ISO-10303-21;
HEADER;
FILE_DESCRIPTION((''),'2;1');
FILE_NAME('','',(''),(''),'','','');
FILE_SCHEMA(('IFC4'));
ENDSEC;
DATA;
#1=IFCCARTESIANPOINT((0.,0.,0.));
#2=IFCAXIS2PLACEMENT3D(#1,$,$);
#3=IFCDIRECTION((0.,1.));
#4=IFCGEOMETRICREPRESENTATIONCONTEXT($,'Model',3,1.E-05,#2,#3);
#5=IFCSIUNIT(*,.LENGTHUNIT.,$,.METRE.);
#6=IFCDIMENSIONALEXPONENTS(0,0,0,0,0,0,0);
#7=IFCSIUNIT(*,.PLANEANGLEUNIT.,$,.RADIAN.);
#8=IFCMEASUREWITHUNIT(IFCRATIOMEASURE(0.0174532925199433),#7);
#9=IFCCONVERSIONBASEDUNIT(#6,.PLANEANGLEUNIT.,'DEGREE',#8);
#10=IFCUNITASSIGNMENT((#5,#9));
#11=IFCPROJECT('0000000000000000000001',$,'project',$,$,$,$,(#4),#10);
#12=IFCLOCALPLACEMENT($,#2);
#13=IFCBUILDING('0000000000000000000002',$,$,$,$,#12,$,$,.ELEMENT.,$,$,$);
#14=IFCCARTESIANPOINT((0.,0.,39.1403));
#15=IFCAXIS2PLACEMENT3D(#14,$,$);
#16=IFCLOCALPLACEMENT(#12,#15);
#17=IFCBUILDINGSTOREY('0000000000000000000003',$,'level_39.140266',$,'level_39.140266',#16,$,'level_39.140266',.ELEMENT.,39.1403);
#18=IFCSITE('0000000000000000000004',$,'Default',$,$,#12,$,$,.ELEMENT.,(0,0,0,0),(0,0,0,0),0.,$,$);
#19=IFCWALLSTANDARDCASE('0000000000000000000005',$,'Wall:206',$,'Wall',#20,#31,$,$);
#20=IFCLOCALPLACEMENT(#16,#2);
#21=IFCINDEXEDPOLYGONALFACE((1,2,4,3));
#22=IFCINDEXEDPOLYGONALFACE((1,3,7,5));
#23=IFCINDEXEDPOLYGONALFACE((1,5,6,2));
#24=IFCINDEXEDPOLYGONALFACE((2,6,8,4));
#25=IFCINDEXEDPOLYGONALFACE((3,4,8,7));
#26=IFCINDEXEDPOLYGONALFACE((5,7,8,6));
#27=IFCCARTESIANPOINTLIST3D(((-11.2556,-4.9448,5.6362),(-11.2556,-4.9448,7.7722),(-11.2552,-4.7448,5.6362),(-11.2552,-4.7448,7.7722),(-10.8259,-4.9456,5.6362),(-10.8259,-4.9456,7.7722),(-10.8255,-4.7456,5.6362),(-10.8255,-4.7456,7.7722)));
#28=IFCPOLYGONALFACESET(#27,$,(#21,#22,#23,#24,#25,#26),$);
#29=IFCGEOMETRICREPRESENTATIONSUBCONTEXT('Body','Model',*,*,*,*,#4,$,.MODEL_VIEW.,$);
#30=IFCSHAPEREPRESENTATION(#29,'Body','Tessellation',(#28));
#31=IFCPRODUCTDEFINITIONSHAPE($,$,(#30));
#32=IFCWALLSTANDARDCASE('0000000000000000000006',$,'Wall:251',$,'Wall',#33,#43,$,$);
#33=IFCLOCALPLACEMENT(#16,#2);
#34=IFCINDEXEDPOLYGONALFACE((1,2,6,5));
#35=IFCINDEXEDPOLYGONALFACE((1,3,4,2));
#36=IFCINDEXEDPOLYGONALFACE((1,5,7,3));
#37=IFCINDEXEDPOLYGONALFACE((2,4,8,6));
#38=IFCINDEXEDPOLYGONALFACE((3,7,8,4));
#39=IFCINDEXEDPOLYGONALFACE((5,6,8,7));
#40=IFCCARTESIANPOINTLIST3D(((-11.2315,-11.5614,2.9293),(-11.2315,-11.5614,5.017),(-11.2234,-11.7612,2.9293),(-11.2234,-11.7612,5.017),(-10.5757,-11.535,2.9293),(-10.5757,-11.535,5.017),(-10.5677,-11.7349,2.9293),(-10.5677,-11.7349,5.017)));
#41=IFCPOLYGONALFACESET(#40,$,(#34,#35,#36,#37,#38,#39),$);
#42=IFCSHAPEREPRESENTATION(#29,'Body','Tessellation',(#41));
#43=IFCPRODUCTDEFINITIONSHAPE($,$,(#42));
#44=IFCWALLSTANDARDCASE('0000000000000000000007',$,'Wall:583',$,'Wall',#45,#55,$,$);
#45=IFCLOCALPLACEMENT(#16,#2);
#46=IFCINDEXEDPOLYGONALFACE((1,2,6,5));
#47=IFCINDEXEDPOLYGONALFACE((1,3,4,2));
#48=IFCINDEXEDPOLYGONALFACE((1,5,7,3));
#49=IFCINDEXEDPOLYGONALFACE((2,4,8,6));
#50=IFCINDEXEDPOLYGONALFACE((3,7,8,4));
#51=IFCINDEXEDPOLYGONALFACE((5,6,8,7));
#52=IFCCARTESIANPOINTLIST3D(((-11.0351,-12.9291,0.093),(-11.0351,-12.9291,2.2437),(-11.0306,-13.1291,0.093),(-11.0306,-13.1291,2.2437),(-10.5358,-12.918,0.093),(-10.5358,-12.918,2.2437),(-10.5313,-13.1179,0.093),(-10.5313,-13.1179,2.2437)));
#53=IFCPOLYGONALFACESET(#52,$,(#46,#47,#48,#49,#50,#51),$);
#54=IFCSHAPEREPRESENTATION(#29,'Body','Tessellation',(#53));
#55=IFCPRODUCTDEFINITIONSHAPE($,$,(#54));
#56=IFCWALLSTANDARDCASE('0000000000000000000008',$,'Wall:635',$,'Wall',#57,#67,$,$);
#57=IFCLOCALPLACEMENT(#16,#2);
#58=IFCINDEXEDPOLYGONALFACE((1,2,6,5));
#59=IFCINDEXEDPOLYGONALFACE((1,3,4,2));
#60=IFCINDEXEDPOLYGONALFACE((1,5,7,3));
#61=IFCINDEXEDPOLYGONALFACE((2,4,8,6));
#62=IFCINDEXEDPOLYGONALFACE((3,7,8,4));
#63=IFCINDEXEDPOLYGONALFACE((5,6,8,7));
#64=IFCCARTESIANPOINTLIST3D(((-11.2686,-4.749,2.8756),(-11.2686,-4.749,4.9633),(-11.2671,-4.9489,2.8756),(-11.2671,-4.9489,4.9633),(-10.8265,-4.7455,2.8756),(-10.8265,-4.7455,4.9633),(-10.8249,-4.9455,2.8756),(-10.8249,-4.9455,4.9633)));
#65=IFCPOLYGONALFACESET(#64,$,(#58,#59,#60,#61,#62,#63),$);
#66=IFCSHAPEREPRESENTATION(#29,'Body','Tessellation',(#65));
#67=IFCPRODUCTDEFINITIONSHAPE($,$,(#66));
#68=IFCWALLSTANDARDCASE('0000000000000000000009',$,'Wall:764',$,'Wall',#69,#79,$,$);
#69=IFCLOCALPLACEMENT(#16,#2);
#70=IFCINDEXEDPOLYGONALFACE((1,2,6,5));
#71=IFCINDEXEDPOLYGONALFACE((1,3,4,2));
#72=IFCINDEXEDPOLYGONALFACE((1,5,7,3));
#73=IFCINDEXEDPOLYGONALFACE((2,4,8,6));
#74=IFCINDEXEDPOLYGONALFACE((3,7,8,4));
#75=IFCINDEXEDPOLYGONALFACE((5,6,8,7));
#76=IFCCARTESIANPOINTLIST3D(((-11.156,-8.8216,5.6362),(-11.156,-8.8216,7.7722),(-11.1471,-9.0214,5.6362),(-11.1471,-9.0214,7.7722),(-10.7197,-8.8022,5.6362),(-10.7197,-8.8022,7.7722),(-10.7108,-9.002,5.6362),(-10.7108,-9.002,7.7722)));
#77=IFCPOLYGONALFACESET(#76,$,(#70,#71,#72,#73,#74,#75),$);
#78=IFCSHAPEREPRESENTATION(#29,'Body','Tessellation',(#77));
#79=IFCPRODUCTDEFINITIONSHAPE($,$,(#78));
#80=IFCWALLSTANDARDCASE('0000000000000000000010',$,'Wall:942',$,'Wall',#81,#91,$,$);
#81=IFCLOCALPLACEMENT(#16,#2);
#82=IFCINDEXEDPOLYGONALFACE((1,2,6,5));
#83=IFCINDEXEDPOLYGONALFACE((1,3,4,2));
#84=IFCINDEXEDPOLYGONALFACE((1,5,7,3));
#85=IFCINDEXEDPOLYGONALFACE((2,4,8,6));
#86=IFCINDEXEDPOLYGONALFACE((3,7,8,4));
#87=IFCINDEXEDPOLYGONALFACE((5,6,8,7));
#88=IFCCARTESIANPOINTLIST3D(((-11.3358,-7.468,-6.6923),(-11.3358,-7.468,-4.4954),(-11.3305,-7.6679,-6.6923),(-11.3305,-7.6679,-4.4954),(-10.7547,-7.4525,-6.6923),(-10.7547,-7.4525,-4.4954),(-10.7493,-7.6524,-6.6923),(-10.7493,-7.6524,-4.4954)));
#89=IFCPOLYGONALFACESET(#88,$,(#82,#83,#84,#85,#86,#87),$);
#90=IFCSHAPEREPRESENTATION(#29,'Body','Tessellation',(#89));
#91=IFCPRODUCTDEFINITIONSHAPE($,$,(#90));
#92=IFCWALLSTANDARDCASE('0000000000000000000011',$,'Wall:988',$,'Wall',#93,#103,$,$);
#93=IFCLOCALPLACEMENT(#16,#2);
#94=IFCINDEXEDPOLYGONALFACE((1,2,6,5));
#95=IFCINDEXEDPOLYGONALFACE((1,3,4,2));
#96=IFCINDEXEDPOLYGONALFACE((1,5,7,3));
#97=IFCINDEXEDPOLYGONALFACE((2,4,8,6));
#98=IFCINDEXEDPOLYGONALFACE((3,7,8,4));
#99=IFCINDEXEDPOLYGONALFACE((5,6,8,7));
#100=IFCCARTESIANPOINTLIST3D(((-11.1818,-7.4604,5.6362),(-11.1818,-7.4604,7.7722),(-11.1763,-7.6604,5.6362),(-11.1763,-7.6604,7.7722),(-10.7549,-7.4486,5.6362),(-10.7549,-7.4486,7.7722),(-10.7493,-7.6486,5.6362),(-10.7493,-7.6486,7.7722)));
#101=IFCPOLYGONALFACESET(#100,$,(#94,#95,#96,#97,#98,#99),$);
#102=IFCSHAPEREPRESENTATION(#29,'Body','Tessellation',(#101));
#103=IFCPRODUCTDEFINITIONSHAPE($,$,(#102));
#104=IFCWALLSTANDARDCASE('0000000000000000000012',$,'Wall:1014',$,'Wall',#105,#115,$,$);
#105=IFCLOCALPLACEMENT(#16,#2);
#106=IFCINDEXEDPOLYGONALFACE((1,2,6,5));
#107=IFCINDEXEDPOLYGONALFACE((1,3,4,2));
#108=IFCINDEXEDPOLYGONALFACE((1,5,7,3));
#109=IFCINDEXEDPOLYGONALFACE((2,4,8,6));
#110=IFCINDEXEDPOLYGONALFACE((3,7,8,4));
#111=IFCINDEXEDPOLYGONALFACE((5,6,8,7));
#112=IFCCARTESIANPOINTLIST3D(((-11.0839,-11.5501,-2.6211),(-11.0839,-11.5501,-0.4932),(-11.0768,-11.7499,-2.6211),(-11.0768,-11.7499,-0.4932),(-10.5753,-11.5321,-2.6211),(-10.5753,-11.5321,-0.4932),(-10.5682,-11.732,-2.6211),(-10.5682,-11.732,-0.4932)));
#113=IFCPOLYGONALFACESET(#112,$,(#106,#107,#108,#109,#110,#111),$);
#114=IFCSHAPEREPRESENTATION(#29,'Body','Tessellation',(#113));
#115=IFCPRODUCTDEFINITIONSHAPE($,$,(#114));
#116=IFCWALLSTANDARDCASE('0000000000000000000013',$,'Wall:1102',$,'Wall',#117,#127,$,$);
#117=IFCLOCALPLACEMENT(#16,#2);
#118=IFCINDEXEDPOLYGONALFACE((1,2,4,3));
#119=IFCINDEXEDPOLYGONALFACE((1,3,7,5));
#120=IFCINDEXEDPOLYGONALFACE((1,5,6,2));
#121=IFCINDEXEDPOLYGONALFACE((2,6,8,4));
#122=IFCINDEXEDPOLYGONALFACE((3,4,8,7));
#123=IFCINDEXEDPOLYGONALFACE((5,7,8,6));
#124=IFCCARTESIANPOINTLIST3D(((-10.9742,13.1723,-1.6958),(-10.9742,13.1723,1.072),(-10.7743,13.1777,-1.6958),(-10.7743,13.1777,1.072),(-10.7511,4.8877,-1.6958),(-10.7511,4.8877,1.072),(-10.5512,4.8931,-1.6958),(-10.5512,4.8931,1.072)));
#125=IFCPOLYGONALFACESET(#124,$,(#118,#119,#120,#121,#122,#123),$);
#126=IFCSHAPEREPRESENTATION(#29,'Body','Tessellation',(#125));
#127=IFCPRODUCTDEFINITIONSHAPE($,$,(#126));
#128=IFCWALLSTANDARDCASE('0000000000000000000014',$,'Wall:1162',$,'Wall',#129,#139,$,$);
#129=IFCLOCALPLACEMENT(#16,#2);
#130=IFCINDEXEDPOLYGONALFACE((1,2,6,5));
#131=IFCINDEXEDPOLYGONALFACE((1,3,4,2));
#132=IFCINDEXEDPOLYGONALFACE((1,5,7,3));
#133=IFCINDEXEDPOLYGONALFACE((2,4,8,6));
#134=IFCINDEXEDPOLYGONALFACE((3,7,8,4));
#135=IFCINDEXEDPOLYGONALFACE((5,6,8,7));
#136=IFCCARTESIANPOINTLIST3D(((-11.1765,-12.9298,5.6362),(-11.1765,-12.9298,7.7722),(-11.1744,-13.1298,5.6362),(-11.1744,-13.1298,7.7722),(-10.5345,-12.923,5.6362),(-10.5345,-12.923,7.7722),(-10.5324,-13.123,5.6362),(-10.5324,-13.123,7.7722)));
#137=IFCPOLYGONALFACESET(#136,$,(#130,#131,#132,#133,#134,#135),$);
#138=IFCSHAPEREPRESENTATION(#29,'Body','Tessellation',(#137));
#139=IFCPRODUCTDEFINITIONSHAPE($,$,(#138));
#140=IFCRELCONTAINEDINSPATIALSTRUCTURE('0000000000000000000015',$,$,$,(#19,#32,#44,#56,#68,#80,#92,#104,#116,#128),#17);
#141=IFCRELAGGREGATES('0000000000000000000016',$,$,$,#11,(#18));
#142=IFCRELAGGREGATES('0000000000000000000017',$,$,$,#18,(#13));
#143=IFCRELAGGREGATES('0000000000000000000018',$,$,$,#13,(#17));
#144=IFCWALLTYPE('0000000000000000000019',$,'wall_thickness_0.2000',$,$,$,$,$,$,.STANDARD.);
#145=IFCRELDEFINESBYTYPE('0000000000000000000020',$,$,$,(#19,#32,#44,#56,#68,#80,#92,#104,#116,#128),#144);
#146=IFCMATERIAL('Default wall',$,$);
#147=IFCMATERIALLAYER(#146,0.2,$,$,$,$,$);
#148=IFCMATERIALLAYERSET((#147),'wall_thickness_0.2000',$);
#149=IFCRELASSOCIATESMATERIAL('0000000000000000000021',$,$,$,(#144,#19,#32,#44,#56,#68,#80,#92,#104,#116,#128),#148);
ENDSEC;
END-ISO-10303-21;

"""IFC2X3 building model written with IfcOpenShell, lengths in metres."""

from ifc_helpers import new_model, entity, si_unit, converted_unit, direction, frame, origin, place, context, subcontext, project, spatial, polyline, outline, extrude, material, layer, layer_set, layer_usage, type_object, element, save


model = new_model("IFC2X3")

# Units and contexts
model_context = context("Model", 3, precision=1e-05, world=origin(), true_north=direction((0.0, 1.0)))
body_context = subcontext(model_context, "Body", "Model", "MODEL_VIEW")
ifc_project = project(units=[si_unit("LENGTHUNIT", "METRE"), converted_unit("PLANEANGLEUNIT", "DEGREE", entity("IfcRatioMeasure", 0.0174532925199433), si_unit("PLANEANGLEUNIT", "RADIAN"), dimensions=[0, 0, 0, 0, 0, 0, 0])], contexts=[model_context])

# Site, building, storey
placement_1 = place(None, origin())
site = spatial("IfcSite", under=ifc_project, at=placement_1, Name="Default", CompositionType="ELEMENT", RefLatitude=(0, 0, 0, 0), RefLongitude=(0, 0, 0, 0), RefElevation=0.0)
building = spatial("IfcBuilding", under=site, at=placement_1, CompositionType="ELEMENT")
storey_placement = place(placement_1, frame((0.0, 0.0, 39.1403)))
storey = spatial("IfcBuildingStorey", under=building, at=storey_placement, Name="level_39.140266", ObjectType="level_39.140266", LongName="level_39.140266", CompositionType="ELEMENT", Elevation=39.1403)

# Walls
ifc_material_1 = material(Name="Default wall")
ifc_layer = layer(ifc_material_1, 0.2)
ifc_layer_set = layer_set([ifc_layer], Name="wall_thickness_0.2000")
ifc_layer_usage = layer_usage(ifc_layer_set, "AXIS2", "POSITIVE", -0.1)
wall_type = type_object("IfcWallType", Name="wall_thickness_0.2000", PredefinedType="STANDARD", material=ifc_layer_set)
placement_2 = place(placement_1, frame((0.0, 0.0, 44.7765)))
wall_1_placement = place(placement_2, frame((-10.8257, -4.8456, 0.0), z_axis=(0.0, 0.0, 1.0), x_axis=(-0.999998, 0.001954, 0.0)))
element("IfcWallStandardCase", 1, at=wall_1_placement, inside=storey, type_object=wall_type, material=ifc_layer_usage, Name="Wall:206", ObjectType="Wall", context=body_context, shape_type="SweptSolid", body=[
    extrude(outline(polyline([(0.4297, -0.1), (0.4297, 0.1), (0.0, 0.1), (0.0, -0.1), (0.4297, -0.1)])), origin(), (0.0, 0.0, 1.0), 2.136),
])
placement_3 = place(placement_1, frame((0.0, 0.0, 42.0696)))
wall_2_placement = place(placement_3, frame((-10.5717, -11.6349, 0.0), z_axis=(0.0, 0.0, 1.0), x_axis=(-0.999193, -0.040157, 0.0)))
element("IfcWallStandardCase", 2, at=wall_2_placement, inside=storey, type_object=wall_type, material=ifc_layer_usage, Name="Wall:251", ObjectType="Wall", context=body_context, shape_type="SweptSolid", body=[
    extrude(outline(polyline([(0.6563, -0.1), (0.6563, 0.1), (0.0, 0.1), (0.0, -0.1), (0.6563, -0.1)])), origin(), (0.0, 0.0, 1.0), 2.0877),
])
placement_4 = place(placement_1, frame((0.0, 0.0, 39.2333)))
wall_3_placement = place(placement_4, frame((-10.5336, -13.0179, 0.0), z_axis=(0.0, 0.0, 1.0), x_axis=(-0.99975, -0.022375, 0.0)))
element("IfcWallStandardCase", 3, at=wall_3_placement, inside=storey, type_object=wall_type, material=ifc_layer_usage, Name="Wall:583", ObjectType="Wall", context=body_context, shape_type="SweptSolid", body=[
    extrude(outline(polyline([(0.4994, -0.1), (0.4994, 0.1), (0.0, 0.1), (0.0, -0.1), (0.4994, -0.1)])), origin(), (0.0, 0.0, 1.0), 2.1507),
])
placement_5 = place(placement_1, frame((0.0, 0.0, 42.0159)))
wall_4_placement = place(placement_5, frame((-10.8257, -4.8455, 0.0), z_axis=(0.0, 0.0, 1.0), x_axis=(-0.99997, -0.00778, 0.0)))
element("IfcWallStandardCase", 4, at=wall_4_placement, inside=storey, type_object=wall_type, material=ifc_layer_usage, Name="Wall:635", ObjectType="Wall", context=body_context, shape_type="SweptSolid", body=[
    extrude(outline(polyline([(0.4422, -0.1), (0.4422, 0.1), (0.0, 0.1), (0.0, -0.1), (0.4422, -0.1)])), origin(), (0.0, 0.0, 1.0), 2.0877),
])
placement_6 = place(placement_1, frame((0.0, 0.0, 44.7765)))
wall_5_placement = place(placement_6, frame((-10.7153, -8.9021, 0.0), z_axis=(0.0, 0.0, 1.0), x_axis=(-0.999018, -0.044312, 0.0)))
element("IfcWallStandardCase", 5, at=wall_5_placement, inside=storey, type_object=wall_type, material=ifc_layer_usage, Name="Wall:764", ObjectType="Wall", context=body_context, shape_type="SweptSolid", body=[
    extrude(outline(polyline([(0.4367, -0.1), (0.4367, 0.1), (0.0, 0.1), (0.0, -0.1), (0.4367, -0.1)])), origin(), (0.0, 0.0, 1.0), 2.136),
])
placement_7 = place(placement_1, frame((0.0, 0.0, 32.448)))
wall_6_placement = place(placement_7, frame((-10.752, -7.5525, 0.0), z_axis=(0.0, 0.0, 1.0), x_axis=(-0.999646, -0.026607, 0.0)))
element("IfcWallStandardCase", 6, at=wall_6_placement, inside=storey, type_object=wall_type, material=ifc_layer_usage, Name="Wall:942", ObjectType="Wall", context=body_context, shape_type="SweptSolid", body=[
    extrude(outline(polyline([(0.5813, -0.1), (0.5813, 0.1), (0.0, 0.1), (0.0, -0.1), (0.5813, -0.1)])), origin(), (0.0, 0.0, 1.0), 2.1969),
])
placement_8 = place(placement_1, frame((0.0, 0.0, 44.7765)))
wall_7_placement = place(placement_8, frame((-10.7521, -7.5486, 0.0), z_axis=(0.0, 0.0, 1.0), x_axis=(-0.999617, -0.027674, 0.0)))
element("IfcWallStandardCase", 7, at=wall_7_placement, inside=storey, type_object=wall_type, material=ifc_layer_usage, Name="Wall:988", ObjectType="Wall", context=body_context, shape_type="SweptSolid", body=[
    extrude(outline(polyline([(0.4271, -0.1), (0.4271, 0.1), (0.0, 0.1), (0.0, -0.1), (0.4271, -0.1)])), origin(), (0.0, 0.0, 1.0), 2.136),
])
placement_9 = place(placement_1, frame((0.0, 0.0, 36.5192)))
wall_8_placement = place(placement_9, frame((-10.5718, -11.632, 0.0), z_axis=(0.0, 0.0, 1.0), x_axis=(-0.999376, -0.03532, 0.0)))
element("IfcWallStandardCase", 8, at=wall_8_placement, inside=storey, type_object=wall_type, material=ifc_layer_usage, Name="Wall:1014", ObjectType="Wall", context=body_context, shape_type="SweptSolid", body=[
    extrude(outline(polyline([(0.5089, -0.1), (0.5089, 0.1), (0.0, 0.1), (0.0, -0.1), (0.5089, -0.1)])), origin(), (0.0, 0.0, 1.0), 2.1279),
])
placement_10 = place(placement_1, frame((0.0, 0.0, 37.4445)))
wall_9_placement = place(placement_10, frame((-10.6512, 4.8904, 0.0), z_axis=(0.0, 0.0, 1.0), x_axis=(-0.026918, 0.999638, 0.0)))
element("IfcWallStandardCase", 9, at=wall_9_placement, inside=storey, type_object=wall_type, material=ifc_layer_usage, Name="Wall:1102", ObjectType="Wall", context=body_context, shape_type="SweptSolid", body=[
    extrude(outline(polyline([(8.2876, -0.1), (8.2876, 0.1), (0.0, 0.1), (0.0, -0.1), (8.2876, -0.1)])), origin(), (0.0, 0.0, 1.0), 2.7678),
])
placement_11 = place(placement_1, frame((0.0, 0.0, 44.7765)))
wall_10_placement = place(placement_11, frame((-10.5334, -13.023, 0.0), z_axis=(0.0, 0.0, 1.0), x_axis=(-0.999945, -0.010496, 0.0)))
element("IfcWallStandardCase", 10, at=wall_10_placement, inside=storey, type_object=wall_type, material=ifc_layer_usage, Name="Wall:1162", ObjectType="Wall", context=body_context, shape_type="SweptSolid", body=[
    extrude(outline(polyline([(0.642, -0.1), (0.642, 0.1), (0.0, 0.1), (0.0, -0.1), (0.642, -0.1)])), origin(), (0.0, 0.0, 1.0), 2.136),
])

save(model, "model.ifc")
